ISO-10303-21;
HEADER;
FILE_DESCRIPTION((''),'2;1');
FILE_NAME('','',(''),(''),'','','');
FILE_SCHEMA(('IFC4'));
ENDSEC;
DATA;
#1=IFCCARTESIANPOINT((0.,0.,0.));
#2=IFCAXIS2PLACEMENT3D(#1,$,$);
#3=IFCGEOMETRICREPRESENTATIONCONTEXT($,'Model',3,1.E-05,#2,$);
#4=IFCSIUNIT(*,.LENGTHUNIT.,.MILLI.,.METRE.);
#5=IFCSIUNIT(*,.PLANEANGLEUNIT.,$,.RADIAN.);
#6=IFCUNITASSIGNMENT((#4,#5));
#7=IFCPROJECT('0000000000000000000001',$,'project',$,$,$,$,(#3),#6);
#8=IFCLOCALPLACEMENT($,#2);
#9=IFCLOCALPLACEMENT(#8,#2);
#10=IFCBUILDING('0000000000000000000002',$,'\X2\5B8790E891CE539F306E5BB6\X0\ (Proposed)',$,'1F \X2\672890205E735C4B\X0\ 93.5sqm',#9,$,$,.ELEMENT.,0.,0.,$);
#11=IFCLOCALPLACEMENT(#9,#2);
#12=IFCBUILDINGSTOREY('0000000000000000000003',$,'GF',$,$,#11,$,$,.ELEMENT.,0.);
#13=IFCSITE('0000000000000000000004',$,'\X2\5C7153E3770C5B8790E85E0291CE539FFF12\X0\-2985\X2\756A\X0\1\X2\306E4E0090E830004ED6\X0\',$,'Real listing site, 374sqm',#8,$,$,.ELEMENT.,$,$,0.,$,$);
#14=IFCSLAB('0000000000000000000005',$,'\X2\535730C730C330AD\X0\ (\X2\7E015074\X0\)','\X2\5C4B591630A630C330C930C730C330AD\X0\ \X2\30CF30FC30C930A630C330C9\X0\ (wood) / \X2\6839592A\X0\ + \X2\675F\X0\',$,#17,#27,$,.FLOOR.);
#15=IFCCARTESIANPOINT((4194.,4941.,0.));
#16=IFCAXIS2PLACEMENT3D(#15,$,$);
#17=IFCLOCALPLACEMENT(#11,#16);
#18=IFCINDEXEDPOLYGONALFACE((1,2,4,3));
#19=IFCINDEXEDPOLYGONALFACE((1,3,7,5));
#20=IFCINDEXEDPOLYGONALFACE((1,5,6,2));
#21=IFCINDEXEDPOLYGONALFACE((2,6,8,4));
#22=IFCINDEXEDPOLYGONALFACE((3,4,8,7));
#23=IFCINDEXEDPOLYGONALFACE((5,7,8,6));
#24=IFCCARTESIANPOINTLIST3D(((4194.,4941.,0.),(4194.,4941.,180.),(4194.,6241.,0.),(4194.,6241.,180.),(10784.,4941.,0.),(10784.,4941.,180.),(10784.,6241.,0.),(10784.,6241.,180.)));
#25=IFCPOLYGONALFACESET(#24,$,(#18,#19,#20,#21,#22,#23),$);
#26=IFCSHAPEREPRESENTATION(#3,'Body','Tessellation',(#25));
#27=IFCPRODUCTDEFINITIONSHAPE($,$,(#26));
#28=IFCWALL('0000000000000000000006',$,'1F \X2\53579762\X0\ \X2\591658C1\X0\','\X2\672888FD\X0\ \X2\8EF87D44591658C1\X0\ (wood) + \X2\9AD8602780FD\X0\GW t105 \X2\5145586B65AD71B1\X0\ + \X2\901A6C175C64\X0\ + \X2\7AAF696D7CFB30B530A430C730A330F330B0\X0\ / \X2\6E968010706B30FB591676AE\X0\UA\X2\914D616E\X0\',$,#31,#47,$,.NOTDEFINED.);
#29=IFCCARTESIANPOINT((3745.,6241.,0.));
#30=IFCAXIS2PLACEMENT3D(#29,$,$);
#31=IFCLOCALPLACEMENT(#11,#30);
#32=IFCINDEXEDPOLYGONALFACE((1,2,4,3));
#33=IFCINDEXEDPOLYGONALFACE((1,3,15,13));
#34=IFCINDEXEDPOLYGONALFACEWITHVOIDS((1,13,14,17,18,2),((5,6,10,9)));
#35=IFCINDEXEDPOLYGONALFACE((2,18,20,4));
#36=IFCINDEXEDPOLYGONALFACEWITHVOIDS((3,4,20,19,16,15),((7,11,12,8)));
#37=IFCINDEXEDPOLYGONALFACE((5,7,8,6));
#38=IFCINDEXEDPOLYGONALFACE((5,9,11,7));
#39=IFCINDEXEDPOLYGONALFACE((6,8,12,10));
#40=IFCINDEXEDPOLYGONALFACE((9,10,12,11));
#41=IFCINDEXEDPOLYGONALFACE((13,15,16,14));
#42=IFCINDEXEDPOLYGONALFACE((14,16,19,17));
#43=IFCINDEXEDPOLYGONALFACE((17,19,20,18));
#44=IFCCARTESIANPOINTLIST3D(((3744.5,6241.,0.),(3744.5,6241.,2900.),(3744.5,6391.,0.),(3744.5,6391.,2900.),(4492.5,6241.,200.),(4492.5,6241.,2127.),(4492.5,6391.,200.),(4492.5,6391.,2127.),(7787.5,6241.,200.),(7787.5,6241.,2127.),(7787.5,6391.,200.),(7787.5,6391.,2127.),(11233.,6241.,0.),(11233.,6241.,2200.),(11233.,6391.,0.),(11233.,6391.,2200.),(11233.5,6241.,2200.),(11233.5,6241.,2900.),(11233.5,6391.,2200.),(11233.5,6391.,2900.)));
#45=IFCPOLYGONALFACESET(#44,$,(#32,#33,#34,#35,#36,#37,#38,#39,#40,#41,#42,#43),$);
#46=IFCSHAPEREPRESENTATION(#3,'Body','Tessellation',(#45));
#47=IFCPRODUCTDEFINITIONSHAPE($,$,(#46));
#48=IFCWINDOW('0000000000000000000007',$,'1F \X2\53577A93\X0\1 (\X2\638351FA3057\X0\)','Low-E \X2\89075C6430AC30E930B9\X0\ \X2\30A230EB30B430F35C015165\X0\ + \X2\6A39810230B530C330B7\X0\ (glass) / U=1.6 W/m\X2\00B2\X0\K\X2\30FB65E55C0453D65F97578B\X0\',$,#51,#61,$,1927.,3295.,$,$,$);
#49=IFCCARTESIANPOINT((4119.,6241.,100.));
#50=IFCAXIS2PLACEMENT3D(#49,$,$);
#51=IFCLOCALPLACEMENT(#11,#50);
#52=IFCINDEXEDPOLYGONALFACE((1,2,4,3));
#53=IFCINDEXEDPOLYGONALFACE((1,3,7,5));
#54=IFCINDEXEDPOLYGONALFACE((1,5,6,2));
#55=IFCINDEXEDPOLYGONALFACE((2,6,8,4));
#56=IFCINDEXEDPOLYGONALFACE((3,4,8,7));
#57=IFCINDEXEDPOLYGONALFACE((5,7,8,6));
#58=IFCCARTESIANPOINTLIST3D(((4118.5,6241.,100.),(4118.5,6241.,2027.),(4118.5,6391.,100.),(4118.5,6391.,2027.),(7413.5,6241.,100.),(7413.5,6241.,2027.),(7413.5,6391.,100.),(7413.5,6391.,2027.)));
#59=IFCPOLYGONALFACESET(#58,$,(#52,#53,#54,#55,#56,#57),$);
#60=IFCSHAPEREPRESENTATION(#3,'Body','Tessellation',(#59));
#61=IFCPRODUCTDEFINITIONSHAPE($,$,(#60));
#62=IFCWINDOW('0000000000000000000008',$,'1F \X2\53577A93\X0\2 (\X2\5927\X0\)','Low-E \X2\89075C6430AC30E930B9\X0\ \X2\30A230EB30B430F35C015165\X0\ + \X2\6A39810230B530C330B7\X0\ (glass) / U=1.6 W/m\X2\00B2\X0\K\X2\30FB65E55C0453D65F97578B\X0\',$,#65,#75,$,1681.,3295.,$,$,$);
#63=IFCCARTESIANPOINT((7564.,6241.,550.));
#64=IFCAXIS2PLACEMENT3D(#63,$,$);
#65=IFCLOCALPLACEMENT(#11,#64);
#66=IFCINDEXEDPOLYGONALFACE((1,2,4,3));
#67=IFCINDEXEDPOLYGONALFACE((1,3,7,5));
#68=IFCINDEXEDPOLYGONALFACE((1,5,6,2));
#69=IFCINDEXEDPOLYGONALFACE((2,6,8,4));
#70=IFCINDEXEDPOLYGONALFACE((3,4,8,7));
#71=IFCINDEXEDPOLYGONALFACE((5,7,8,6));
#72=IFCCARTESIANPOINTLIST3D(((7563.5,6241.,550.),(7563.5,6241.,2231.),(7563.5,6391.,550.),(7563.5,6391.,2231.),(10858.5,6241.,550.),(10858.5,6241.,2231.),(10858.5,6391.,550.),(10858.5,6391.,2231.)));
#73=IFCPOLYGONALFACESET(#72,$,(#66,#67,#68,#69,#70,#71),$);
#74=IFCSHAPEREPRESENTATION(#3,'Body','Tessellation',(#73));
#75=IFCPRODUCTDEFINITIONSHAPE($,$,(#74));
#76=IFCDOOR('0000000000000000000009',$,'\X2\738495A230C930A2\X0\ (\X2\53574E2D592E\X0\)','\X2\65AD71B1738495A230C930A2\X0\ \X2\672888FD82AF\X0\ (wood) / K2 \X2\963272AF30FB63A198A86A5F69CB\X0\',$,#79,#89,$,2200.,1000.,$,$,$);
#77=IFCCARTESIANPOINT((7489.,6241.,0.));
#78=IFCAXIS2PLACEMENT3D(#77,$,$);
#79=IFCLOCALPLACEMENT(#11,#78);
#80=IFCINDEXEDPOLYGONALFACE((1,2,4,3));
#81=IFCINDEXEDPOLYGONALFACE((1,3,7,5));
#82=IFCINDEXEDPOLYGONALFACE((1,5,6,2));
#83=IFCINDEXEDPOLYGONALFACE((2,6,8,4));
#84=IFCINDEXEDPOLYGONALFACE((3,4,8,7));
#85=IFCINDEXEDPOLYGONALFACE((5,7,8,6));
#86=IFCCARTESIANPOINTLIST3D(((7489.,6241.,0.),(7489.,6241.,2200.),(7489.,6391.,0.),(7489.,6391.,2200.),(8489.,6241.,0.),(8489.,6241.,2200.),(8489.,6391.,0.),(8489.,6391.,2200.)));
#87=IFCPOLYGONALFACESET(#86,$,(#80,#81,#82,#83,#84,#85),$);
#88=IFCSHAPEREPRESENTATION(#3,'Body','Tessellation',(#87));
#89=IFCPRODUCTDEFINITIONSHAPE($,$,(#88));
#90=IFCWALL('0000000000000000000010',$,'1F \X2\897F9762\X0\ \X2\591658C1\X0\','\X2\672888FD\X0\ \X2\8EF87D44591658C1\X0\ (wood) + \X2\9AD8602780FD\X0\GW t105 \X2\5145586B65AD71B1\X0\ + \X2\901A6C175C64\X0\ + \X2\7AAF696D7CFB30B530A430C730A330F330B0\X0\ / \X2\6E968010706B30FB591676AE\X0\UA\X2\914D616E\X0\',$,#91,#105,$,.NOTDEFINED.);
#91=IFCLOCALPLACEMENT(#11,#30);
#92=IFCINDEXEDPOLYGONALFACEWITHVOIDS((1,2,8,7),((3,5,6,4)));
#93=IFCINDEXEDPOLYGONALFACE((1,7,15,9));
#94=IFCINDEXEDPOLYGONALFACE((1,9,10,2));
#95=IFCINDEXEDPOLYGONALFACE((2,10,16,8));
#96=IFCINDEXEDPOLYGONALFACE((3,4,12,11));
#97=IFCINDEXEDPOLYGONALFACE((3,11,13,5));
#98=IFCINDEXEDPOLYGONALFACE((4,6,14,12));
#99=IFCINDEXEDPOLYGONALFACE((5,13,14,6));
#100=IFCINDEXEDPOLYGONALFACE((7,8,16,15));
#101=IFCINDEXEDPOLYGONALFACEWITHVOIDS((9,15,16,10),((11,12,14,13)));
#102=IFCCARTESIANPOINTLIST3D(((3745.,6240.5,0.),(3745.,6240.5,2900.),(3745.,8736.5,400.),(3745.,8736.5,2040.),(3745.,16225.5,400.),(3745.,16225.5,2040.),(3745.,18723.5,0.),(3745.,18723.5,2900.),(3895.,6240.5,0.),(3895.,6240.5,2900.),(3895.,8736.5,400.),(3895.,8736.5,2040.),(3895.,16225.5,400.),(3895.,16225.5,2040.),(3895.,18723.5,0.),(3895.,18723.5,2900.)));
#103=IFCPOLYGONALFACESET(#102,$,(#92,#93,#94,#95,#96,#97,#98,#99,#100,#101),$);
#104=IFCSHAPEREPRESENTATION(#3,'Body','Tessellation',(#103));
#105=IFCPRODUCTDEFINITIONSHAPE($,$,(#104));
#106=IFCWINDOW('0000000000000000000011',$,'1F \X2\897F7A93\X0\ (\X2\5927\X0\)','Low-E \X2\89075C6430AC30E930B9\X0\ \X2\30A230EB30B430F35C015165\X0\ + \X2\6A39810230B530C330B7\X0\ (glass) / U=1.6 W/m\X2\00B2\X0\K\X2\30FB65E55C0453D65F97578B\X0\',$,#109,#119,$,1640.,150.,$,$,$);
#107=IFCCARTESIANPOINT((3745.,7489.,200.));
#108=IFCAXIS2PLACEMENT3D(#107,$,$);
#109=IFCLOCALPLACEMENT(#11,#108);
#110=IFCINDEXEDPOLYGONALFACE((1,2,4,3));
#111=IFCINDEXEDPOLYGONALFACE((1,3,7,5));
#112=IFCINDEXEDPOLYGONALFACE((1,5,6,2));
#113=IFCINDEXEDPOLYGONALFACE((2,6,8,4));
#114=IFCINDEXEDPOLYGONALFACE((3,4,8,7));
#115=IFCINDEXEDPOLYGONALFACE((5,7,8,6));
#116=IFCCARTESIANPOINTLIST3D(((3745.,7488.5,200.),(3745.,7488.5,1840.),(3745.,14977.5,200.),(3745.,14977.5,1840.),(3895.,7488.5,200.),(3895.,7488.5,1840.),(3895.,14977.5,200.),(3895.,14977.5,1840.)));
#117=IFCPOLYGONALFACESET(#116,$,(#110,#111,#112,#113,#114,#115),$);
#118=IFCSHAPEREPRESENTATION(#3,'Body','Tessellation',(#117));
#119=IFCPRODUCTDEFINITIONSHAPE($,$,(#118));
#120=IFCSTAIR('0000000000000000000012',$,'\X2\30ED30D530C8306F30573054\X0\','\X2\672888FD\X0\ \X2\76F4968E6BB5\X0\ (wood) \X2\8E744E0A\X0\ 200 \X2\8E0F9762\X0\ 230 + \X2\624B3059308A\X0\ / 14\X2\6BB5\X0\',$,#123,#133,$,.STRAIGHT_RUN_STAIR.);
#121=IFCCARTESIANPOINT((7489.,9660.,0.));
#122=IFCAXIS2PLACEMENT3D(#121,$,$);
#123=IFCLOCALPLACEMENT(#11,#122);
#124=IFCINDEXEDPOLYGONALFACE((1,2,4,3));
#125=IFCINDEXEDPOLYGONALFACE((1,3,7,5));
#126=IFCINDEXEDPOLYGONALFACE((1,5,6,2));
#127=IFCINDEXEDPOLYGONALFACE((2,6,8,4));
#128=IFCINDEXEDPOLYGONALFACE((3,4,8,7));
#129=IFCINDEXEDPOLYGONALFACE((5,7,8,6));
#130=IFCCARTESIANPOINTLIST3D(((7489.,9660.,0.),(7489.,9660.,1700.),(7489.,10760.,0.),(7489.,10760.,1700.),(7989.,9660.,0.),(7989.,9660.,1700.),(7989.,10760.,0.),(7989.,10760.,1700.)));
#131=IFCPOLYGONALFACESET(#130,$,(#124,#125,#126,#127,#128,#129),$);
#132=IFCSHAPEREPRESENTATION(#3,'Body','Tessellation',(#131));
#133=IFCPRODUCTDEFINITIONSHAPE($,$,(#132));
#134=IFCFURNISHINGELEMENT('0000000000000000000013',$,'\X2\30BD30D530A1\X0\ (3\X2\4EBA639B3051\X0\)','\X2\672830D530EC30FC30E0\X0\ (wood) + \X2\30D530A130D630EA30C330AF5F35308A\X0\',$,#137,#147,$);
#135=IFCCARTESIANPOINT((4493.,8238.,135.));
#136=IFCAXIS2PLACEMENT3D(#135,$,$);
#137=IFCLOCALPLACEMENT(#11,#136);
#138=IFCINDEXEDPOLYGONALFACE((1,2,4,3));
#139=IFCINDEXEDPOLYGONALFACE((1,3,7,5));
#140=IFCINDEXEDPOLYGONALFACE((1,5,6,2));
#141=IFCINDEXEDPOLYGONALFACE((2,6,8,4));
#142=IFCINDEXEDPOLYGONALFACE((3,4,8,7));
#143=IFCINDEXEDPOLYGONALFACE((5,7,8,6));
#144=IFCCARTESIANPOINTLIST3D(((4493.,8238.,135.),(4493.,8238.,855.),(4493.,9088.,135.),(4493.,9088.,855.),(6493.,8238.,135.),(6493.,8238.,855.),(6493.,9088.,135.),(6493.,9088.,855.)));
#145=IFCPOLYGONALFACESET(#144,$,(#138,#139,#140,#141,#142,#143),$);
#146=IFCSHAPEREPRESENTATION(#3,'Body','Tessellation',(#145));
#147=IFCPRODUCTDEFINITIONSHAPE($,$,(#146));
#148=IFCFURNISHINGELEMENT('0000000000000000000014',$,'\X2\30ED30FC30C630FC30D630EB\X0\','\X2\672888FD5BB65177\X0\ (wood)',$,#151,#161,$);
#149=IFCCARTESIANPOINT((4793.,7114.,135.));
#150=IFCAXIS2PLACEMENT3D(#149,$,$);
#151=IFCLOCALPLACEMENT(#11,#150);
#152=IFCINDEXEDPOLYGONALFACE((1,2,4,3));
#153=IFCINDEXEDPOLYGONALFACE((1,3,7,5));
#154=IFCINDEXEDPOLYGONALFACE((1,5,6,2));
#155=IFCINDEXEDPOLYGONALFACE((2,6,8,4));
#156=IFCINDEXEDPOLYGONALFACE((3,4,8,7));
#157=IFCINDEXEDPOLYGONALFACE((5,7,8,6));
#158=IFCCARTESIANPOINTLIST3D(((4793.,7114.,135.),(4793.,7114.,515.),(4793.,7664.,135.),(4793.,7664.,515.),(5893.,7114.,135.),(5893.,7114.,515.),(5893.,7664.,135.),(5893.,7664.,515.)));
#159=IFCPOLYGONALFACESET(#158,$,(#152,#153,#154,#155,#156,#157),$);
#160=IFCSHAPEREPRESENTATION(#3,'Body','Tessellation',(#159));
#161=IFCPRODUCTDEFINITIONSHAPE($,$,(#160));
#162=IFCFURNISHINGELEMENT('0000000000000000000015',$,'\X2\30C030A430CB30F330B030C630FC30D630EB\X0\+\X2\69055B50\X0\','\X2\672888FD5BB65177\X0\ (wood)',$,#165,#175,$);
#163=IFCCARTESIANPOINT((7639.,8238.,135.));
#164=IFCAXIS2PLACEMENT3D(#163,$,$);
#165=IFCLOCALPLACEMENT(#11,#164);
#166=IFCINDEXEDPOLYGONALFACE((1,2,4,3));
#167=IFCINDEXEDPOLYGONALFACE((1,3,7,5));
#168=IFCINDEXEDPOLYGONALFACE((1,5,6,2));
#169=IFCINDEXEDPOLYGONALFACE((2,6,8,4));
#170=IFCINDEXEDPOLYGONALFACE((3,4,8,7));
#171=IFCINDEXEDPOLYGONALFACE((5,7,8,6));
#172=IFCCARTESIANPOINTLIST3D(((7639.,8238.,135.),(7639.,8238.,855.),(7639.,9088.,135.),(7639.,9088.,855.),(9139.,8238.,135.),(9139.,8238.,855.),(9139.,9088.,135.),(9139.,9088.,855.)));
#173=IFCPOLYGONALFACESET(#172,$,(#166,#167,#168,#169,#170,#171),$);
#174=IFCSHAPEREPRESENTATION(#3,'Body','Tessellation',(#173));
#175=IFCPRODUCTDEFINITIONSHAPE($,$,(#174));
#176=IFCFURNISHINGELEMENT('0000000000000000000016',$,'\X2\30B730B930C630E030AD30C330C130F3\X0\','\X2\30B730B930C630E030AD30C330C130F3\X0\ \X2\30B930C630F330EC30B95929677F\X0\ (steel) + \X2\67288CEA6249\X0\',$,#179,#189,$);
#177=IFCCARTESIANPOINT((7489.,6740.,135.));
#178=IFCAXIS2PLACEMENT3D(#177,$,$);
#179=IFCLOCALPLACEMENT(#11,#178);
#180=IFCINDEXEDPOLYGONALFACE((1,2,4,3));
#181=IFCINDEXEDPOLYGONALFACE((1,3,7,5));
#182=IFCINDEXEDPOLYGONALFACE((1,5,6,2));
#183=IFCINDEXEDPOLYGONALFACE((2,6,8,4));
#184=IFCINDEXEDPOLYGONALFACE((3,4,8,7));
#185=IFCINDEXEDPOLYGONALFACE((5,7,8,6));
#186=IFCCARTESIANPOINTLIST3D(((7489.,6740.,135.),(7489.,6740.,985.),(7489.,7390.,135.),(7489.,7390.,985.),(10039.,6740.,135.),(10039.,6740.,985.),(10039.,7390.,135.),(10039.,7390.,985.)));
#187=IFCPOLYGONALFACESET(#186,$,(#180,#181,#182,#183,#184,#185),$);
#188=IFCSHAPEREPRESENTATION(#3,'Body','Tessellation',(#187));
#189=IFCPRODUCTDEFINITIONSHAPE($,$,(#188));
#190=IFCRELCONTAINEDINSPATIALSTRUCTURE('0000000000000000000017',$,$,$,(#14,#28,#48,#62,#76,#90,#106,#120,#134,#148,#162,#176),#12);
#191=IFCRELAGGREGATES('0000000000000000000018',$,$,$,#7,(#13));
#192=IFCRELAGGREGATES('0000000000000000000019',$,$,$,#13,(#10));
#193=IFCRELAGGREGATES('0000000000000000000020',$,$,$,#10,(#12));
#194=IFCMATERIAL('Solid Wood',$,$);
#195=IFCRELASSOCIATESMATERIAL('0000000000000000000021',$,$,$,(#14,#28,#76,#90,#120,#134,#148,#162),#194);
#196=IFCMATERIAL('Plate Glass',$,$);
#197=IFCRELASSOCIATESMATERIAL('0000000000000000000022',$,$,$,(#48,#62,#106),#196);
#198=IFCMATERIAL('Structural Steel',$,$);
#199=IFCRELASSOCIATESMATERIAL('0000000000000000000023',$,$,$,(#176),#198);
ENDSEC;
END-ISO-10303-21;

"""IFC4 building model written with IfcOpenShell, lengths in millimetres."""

from ifc_helpers import new_model, si_unit, frame, frame_2d, origin, place, context, project, spatial, rectangle, extrude, material, element, fill, save


model = new_model("IFC4")

# Units and contexts
model_context = context("Model", 3, precision=1e-05, world=origin())
ifc_project = project(units=[si_unit("LENGTHUNIT", "METRE", prefix="MILLI"), si_unit("PLANEANGLEUNIT", "RADIAN")], contexts=[model_context])

# Site, building, storey
site_placement = place(None, origin())
site = spatial("IfcSite", under=ifc_project, at=site_placement, Name="山口県宇部市野原２-2985番1の一部　他", ObjectType="Real listing site, 374sqm", CompositionType="ELEMENT", RefElevation=0.0)
building_placement = place(site_placement, origin())
building = spatial("IfcBuilding", under=site, at=building_placement, Name="宇部野原の家 (Proposed)", ObjectType="1F 木造平屋 93.5sqm", CompositionType="ELEMENT", ElevationOfRefHeight=0.0, ElevationOfTerrain=0.0)
storey_placement = place(building_placement, origin())
storey = spatial("IfcBuildingStorey", under=building, at=storey_placement, Name="GF", CompositionType="ELEMENT", Elevation=0.0)

# Slab
ifc_material_1 = material(Name="Solid Wood")
slab_1_placement = place(storey_placement, frame((4194.0, 4941.0, 0.0)))
element("IfcSlab", 1, at=slab_1_placement, inside=storey, material=ifc_material_1, Name="南デッキ (縁側)", Description="屋外ウッドデッキ ハードウッド (wood) / 根太 + 束", PredefinedType="FLOOR", context=model_context, shape_type="SweptSolid", body=[
    extrude(rectangle(XDim=6590.0, YDim=1300.0, at=frame_2d((3295.0, 650.0))), frame((4194.0, 4941.0, 0.0)), (0.0, 0.0, 1.0), 180.0),
])

# Wall, openings, windows, door
wall_1_placement = place(storey_placement, frame((3745.0, 6241.0, 0.0)))
wall_1 = element("IfcWall", 2, at=wall_1_placement, inside=storey, material=ifc_material_1, Name="1F 南面 外壁", Description="木製 軸組外壁 (wood) + 高性能GW t105 充填断熱 + 通気層 + 窯業系サイディング / 準耐火・外皮UA配慮", PredefinedType="NOTDEFINED", context=model_context, shape_type="SweptSolid", body=[
    extrude(rectangle(XDim=7489.0, YDim=150.0, at=frame_2d((3744.0, 75.0))), frame((3745.0, 6241.0, 0.0)), (0.0, 0.0, 1.0), 2900.0),
])
opening_1_placement = place(storey_placement, frame((4119.0, 6241.0, 100.0)))
opening_1 = element("IfcOpeningElement", 3, at=opening_1_placement, cuts=wall_1, PredefinedType="NOTDEFINED", context=model_context, shape_type="SweptSolid", body=[
    extrude(rectangle(XDim=3295.0, YDim=150.0, at=frame_2d((1647.0, 75.0))), frame((4119.0, 6241.0, 100.0)), (0.0, 0.0, 1.0), 1927.0),
])
opening_2_placement = place(storey_placement, frame((7564.0, 6241.0, 550.0)))
opening_2 = element("IfcOpeningElement", 4, at=opening_2_placement, cuts=wall_1, PredefinedType="NOTDEFINED", context=model_context, shape_type="SweptSolid", body=[
    extrude(rectangle(XDim=3295.0, YDim=150.0, at=frame_2d((1647.0, 75.0))), frame((7564.0, 6241.0, 550.0)), (0.0, 0.0, 1.0), 1681.0),
])
opening_3_placement = place(storey_placement, frame((7489.0, 6241.0, 0.0)))
opening_3 = element("IfcOpeningElement", 5, at=opening_3_placement, cuts=wall_1, PredefinedType="NOTDEFINED", context=model_context, shape_type="SweptSolid", body=[
    extrude(rectangle(XDim=1000.0, YDim=150.0, at=frame_2d((500.0, 75.0))), frame((7489.0, 6241.0, 0.0)), (0.0, 0.0, 1.0), 2200.0),
])
ifc_material_2 = material(Name="Plate Glass")
window_1_placement = place(storey_placement, frame((4119.0, 6241.0, 100.0)))
window_1 = element("IfcWindow", 6, at=window_1_placement, inside=storey, material=ifc_material_2, Name="1F 南窓1 (掃出し)", Description="Low-E 複層ガラス アルゴン封入 + 樹脂サッシ (glass) / U=1.6 W/m²K・日射取得型", OverallHeight=1927.0, OverallWidth=3295.0, context=model_context, shape_type="SweptSolid", body=[
    extrude(rectangle(XDim=3295.0, YDim=150.0, at=frame_2d((1647.0, 75.0))), frame((4119.0, 6241.0, 100.0)), (0.0, 0.0, 1.0), 1927.0),
])
fill(opening_1, window_1)
window_2_placement = place(storey_placement, frame((7564.0, 6241.0, 550.0)))
window_2 = element("IfcWindow", 7, at=window_2_placement, inside=storey, material=ifc_material_2, Name="1F 南窓2 (大)", Description="Low-E 複層ガラス アルゴン封入 + 樹脂サッシ (glass) / U=1.6 W/m²K・日射取得型", OverallHeight=1681.0, OverallWidth=3295.0, context=model_context, shape_type="SweptSolid", body=[
    extrude(rectangle(XDim=3295.0, YDim=150.0, at=frame_2d((1647.0, 75.0))), frame((7564.0, 6241.0, 550.0)), (0.0, 0.0, 1.0), 1681.0),
])
fill(opening_2, window_2)
door_placement = place(storey_placement, frame((7489.0, 6241.0, 0.0)))
door = element("IfcDoor", 8, at=door_placement, inside=storey, material=ifc_material_1, Name="玄関ドア (南中央)", Description="断熱玄関ドア 木製芯 (wood) / K2 防犯・採風機構", OverallHeight=2200.0, OverallWidth=1000.0, context=model_context, shape_type="SweptSolid", body=[
    extrude(rectangle(XDim=1000.0, YDim=150.0, at=frame_2d((500.0, 75.0))), frame((7489.0, 6241.0, 0.0)), (0.0, 0.0, 1.0), 2200.0),
])
fill(opening_3, door)

# Wall, opening, window
wall_2_placement = place(storey_placement, frame((3745.0, 6241.0, 0.0)))
wall_2 = element("IfcWall", 9, at=wall_2_placement, inside=storey, material=ifc_material_1, Name="1F 西面 外壁", Description="木製 軸組外壁 (wood) + 高性能GW t105 充填断熱 + 通気層 + 窯業系サイディング / 準耐火・外皮UA配慮", PredefinedType="NOTDEFINED", context=model_context, shape_type="SweptSolid", body=[
    extrude(rectangle(XDim=150.0, YDim=12483.0, at=frame_2d((75.0, 6241.0))), frame((3745.0, 6241.0, 0.0)), (0.0, 0.0, 1.0), 2900.0),
])
opening_4_placement = place(storey_placement, frame((3745.0, 7489.0, 200.0)))
opening_4 = element("IfcOpeningElement", 10, at=opening_4_placement, cuts=wall_2, PredefinedType="NOTDEFINED", context=model_context, shape_type="SweptSolid", body=[
    extrude(rectangle(XDim=150.0, YDim=7489.0, at=frame_2d((75.0, 3744.0))), frame((3745.0, 7489.0, 200.0)), (0.0, 0.0, 1.0), 1640.0),
])
window_3_placement = place(storey_placement, frame((3745.0, 7489.0, 200.0)))
window_3 = element("IfcWindow", 11, at=window_3_placement, inside=storey, material=ifc_material_2, Name="1F 西窓 (大)", Description="Low-E 複層ガラス アルゴン封入 + 樹脂サッシ (glass) / U=1.6 W/m²K・日射取得型", OverallHeight=1640.0, OverallWidth=150.0, context=model_context, shape_type="SweptSolid", body=[
    extrude(rectangle(XDim=150.0, YDim=7489.0, at=frame_2d((75.0, 3744.0))), frame((3745.0, 7489.0, 200.0)), (0.0, 0.0, 1.0), 1640.0),
])
fill(opening_4, window_3)

# Stair
stair_placement = place(storey_placement, frame((7489.0, 9660.0, 0.0)))
element("IfcStair", 12, at=stair_placement, inside=storey, material=ifc_material_1, Name="ロフトはしご", Description="木製 直階段 (wood) 蹴上 200 踏面 230 + 手すり / 14段", PredefinedType="STRAIGHT_RUN_STAIR", context=model_context, shape_type="SweptSolid", body=[
    extrude(rectangle(XDim=500.0, YDim=1100.0, at=frame_2d((250.0, 550.0))), frame((7489.0, 9660.0, 0.0)), (0.0, 0.0, 1.0), 1700.0),
])

# Shared definitions
ifc_material_3 = material(Name="Structural Steel")

# Furnishing elements
furnishing_1_placement = place(storey_placement, frame((4493.0, 8238.0, 135.0)))
element("IfcFurnishingElement", 13, at=furnishing_1_placement, inside=storey, material=ifc_material_1, Name="ソファ (3人掛け)", Description="木フレーム (wood) + ファブリック張り", context=model_context, shape_type="SweptSolid", body=[
    extrude(rectangle(XDim=2000.0, YDim=850.0, at=frame_2d((1000.0, 425.0))), frame((4493.0, 8238.0, 135.0)), (0.0, 0.0, 1.0), 720.0),
])
furnishing_2_placement = place(storey_placement, frame((4793.0, 7114.0, 135.0)))
element("IfcFurnishingElement", 14, at=furnishing_2_placement, inside=storey, material=ifc_material_1, Name="ローテーブル", Description="木製家具 (wood)", context=model_context, shape_type="SweptSolid", body=[
    extrude(rectangle(XDim=1100.0, YDim=550.0, at=frame_2d((550.0, 275.0))), frame((4793.0, 7114.0, 135.0)), (0.0, 0.0, 1.0), 380.0),
])
furnishing_3_placement = place(storey_placement, frame((7639.0, 8238.0, 135.0)))
element("IfcFurnishingElement", 15, at=furnishing_3_placement, inside=storey, material=ifc_material_1, Name="ダイニングテーブル+椅子", Description="木製家具 (wood)", context=model_context, shape_type="SweptSolid", body=[
    extrude(rectangle(XDim=1500.0, YDim=850.0, at=frame_2d((750.0, 425.0))), frame((7639.0, 8238.0, 135.0)), (0.0, 0.0, 1.0), 720.0),
])
furnishing_4_placement = place(storey_placement, frame((7489.0, 6740.0, 135.0)))
element("IfcFurnishingElement", 16, at=furnishing_4_placement, inside=storey, material=ifc_material_3, Name="システムキッチン", Description="システムキッチン ステンレス天板 (steel) + 木質扉", context=model_context, shape_type="SweptSolid", body=[
    extrude(rectangle(XDim=2550.0, YDim=650.0, at=frame_2d((1275.0, 325.0))), frame((7489.0, 6740.0, 135.0)), (0.0, 0.0, 1.0), 850.0),
])

save(model, "model.ifc")
